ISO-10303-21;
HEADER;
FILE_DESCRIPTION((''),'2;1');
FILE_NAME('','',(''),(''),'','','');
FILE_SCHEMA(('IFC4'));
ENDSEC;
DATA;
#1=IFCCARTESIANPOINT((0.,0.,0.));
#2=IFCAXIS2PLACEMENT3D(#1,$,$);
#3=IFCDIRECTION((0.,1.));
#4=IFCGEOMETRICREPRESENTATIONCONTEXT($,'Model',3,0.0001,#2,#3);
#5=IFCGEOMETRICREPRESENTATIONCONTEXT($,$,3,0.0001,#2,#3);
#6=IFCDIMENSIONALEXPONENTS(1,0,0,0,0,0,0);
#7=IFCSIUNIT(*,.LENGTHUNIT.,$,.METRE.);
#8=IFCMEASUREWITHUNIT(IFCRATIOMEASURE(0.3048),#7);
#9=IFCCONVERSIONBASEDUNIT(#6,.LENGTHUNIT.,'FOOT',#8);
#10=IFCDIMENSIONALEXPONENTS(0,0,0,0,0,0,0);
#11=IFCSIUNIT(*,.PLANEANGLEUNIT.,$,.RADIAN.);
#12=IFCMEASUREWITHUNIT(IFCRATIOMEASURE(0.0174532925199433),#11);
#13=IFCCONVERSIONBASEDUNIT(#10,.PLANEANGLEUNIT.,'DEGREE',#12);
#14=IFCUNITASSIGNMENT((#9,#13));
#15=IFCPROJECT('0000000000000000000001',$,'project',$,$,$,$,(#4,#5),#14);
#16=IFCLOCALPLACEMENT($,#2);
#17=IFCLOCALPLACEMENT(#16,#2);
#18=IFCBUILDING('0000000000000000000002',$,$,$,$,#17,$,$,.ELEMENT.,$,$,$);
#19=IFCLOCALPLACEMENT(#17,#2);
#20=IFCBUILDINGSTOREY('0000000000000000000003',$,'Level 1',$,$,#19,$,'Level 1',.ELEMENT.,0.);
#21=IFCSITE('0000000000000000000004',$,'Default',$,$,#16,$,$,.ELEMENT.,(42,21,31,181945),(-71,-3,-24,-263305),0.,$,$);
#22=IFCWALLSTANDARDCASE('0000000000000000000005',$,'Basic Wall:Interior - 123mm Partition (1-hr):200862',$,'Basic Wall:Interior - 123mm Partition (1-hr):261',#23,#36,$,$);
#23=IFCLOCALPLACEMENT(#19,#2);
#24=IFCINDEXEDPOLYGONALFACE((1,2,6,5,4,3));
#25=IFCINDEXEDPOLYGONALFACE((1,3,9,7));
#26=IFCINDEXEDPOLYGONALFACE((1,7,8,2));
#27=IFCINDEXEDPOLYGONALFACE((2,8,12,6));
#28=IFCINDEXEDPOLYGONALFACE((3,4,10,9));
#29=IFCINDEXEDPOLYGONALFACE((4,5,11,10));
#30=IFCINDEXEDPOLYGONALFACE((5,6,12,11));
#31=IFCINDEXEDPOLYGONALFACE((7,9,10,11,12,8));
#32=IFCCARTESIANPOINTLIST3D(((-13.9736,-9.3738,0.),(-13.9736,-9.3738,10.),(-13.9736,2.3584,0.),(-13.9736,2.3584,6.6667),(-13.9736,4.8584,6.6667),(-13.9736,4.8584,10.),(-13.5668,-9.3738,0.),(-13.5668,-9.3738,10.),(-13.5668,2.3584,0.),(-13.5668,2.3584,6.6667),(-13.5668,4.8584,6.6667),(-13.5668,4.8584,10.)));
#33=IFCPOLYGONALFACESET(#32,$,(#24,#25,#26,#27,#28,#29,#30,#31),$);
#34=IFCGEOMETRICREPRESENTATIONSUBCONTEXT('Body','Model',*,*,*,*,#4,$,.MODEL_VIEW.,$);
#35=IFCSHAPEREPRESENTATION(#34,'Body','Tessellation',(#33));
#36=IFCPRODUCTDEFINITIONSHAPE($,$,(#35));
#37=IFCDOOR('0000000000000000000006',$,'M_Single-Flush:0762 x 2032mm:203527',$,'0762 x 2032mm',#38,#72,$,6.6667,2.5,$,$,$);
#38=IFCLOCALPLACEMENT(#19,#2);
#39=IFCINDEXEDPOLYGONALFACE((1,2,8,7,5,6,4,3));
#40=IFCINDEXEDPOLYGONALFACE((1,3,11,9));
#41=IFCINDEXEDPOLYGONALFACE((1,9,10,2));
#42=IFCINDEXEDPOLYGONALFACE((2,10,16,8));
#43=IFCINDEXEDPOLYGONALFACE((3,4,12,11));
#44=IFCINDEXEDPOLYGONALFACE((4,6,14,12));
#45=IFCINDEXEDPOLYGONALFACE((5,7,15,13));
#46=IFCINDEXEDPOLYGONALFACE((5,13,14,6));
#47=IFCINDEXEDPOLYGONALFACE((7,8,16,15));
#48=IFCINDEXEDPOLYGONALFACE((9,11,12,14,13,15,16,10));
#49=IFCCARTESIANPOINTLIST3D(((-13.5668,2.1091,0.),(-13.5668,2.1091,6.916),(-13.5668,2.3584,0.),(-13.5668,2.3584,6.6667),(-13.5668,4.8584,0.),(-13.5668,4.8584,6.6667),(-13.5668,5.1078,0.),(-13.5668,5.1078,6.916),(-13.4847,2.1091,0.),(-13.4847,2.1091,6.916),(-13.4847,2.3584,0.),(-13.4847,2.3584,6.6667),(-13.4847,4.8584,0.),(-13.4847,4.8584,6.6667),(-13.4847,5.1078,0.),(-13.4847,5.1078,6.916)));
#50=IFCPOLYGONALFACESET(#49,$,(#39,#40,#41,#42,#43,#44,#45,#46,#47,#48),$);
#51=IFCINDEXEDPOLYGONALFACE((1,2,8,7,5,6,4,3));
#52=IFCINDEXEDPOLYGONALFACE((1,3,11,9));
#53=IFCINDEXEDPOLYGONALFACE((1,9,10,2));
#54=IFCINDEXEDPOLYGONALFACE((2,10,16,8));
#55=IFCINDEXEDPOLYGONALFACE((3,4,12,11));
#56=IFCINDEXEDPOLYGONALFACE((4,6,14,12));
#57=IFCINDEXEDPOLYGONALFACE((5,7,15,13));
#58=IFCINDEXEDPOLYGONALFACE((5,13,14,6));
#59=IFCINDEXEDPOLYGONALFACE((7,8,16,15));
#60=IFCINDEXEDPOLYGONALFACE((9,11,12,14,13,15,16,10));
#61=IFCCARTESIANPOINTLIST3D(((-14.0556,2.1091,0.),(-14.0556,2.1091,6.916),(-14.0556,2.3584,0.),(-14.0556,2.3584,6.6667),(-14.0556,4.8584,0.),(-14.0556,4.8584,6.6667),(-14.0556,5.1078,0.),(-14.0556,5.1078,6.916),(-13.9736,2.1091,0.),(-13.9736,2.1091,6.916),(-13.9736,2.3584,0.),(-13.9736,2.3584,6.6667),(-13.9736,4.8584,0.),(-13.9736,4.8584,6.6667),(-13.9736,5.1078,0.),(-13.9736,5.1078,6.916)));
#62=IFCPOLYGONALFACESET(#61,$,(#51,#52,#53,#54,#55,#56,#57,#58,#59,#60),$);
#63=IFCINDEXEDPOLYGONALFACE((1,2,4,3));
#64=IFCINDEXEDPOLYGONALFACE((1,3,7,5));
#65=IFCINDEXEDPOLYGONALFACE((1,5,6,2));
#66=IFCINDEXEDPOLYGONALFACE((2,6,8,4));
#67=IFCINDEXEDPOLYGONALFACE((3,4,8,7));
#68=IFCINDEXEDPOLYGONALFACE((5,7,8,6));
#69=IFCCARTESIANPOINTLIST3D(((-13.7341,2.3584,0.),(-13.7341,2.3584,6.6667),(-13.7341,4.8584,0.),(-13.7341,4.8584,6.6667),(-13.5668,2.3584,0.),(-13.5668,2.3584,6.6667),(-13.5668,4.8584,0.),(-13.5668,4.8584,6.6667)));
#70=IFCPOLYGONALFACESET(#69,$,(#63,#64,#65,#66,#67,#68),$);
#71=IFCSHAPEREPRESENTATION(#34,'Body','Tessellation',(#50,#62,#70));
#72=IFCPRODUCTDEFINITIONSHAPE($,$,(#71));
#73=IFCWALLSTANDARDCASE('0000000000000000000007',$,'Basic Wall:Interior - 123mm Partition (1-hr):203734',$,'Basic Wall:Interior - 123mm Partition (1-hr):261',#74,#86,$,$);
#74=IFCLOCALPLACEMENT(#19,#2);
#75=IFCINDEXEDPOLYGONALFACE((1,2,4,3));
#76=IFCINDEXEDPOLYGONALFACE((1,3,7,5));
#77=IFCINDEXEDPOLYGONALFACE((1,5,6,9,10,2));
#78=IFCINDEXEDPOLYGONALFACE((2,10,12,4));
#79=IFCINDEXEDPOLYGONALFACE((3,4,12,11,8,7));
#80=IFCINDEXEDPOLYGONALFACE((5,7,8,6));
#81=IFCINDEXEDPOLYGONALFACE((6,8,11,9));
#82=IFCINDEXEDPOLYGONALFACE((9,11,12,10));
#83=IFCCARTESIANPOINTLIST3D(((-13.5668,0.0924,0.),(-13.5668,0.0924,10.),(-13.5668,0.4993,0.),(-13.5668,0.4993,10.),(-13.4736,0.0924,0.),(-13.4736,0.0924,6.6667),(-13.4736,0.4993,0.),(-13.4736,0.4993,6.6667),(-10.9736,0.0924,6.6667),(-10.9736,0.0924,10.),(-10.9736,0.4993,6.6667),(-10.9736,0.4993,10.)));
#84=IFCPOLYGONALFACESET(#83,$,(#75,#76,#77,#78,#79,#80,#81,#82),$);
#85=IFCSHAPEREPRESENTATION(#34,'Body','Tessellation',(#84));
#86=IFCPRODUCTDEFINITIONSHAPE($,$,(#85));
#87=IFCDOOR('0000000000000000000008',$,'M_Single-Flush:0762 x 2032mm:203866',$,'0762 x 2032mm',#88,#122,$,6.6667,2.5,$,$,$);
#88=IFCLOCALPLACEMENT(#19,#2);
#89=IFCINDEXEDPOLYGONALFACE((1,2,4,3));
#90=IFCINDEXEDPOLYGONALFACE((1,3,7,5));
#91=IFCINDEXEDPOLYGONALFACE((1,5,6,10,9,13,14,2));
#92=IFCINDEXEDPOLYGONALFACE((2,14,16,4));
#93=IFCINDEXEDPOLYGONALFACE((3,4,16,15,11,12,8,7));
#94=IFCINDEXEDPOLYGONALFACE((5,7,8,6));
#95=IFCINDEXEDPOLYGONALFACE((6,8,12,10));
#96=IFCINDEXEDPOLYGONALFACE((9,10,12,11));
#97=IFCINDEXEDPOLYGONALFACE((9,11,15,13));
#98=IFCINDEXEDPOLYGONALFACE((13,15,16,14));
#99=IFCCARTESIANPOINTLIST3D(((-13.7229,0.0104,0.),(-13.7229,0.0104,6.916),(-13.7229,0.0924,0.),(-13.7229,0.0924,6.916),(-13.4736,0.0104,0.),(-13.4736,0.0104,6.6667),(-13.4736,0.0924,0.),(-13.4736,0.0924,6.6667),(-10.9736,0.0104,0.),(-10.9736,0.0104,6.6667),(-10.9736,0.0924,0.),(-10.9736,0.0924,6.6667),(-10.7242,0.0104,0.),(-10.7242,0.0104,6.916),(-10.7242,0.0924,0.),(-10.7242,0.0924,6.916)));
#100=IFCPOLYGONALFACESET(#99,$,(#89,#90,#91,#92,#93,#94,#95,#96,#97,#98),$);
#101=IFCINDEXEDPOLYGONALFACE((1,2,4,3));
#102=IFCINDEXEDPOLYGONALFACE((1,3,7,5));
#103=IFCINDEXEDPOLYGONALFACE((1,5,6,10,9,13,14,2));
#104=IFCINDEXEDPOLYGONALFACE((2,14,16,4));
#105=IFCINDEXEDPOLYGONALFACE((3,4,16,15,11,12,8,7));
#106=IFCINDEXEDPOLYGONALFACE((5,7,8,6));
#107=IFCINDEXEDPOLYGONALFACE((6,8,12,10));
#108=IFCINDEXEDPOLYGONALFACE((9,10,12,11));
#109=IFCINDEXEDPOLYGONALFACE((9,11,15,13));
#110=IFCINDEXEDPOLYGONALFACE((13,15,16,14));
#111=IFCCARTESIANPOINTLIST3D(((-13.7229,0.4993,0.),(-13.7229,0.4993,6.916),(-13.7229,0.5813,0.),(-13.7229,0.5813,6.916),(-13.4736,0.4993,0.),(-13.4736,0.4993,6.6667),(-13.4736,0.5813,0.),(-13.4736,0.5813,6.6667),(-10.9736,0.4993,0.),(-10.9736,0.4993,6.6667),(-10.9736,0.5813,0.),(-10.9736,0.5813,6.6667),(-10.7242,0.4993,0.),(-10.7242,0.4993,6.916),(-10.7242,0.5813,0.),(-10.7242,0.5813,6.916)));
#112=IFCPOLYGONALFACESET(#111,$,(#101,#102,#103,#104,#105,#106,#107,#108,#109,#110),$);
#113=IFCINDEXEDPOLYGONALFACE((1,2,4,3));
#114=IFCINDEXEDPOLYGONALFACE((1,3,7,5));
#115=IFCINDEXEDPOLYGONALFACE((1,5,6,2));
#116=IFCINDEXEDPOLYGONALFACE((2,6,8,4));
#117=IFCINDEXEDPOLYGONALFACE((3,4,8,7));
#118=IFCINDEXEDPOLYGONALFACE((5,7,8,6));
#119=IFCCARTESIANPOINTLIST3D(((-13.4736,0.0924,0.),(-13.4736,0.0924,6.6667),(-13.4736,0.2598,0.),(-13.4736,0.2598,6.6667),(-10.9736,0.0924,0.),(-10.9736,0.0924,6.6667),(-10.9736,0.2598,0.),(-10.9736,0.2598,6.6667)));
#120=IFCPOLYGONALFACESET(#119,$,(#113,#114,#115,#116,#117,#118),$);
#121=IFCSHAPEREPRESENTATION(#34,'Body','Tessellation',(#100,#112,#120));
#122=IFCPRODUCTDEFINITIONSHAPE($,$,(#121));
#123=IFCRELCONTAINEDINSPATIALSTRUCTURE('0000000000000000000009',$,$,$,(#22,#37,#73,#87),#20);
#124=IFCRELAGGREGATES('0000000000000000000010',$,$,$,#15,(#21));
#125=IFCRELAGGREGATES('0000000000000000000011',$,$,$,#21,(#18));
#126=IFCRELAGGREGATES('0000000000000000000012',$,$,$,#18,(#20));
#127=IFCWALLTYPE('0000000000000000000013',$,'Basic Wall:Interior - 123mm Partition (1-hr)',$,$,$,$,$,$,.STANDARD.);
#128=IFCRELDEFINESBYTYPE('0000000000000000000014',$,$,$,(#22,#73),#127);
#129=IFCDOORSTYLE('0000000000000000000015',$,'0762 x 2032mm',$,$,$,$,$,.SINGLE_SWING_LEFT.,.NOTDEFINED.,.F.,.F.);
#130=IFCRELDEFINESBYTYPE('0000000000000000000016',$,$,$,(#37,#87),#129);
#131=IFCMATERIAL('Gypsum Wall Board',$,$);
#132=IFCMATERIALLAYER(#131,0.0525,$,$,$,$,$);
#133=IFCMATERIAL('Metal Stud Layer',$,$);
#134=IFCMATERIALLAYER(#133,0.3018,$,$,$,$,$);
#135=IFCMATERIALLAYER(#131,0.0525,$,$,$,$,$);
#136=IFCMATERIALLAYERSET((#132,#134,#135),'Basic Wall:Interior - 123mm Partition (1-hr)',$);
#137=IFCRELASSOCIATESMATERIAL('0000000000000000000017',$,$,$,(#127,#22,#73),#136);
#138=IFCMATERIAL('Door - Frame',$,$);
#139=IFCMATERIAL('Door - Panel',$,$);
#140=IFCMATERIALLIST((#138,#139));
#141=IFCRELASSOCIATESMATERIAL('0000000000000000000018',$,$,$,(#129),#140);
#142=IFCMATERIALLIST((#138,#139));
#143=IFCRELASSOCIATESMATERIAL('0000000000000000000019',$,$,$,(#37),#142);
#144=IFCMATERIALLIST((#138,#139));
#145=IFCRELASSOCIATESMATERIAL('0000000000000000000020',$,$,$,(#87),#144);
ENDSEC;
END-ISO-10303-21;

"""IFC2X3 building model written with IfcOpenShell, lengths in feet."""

from ifc_helpers import new_model, entity, si_unit, converted_unit, direction, frame, frame_2d, origin, origin_2d_with_axis, place, context, subcontext, project, spatial, polyline, rectangle, outline, extrude, source, transform, mapped, material, material_list, layer, layer_set, layer_usage, type_object, type_shapes, element, fill, save


model = new_model("IFC2X3")

# Units and contexts
model_context = context("Model", 3, precision=0.0001, world=origin(), true_north=direction((0.0, 1.0)))
context_of_model = context(None, 3, precision=0.0001, world=origin(), true_north=direction((0.0, 1.0)))
body_context = subcontext(model_context, "Body", "Model", "MODEL_VIEW")
ifc_project = project(units=[converted_unit("LENGTHUNIT", "FOOT", entity("IfcRatioMeasure", 0.3048), si_unit("LENGTHUNIT", "METRE"), dimensions=[1, 0, 0, 0, 0, 0, 0]), converted_unit("PLANEANGLEUNIT", "DEGREE", entity("IfcRatioMeasure", 0.0174532925199433), si_unit("PLANEANGLEUNIT", "RADIAN"), dimensions=[0, 0, 0, 0, 0, 0, 0])], contexts=[model_context, context_of_model])

# Site, building, storey
site_placement = place(None, origin())
site = spatial("IfcSite", under=ifc_project, at=site_placement, Name="Default", CompositionType="ELEMENT", RefLatitude=(42, 21, 31, 181945), RefLongitude=(-71, -3, -24, -263305), RefElevation=0.0)
building_placement = place(site_placement, origin())
building = spatial("IfcBuilding", under=site, at=building_placement, CompositionType="ELEMENT")
storey_placement = place(building_placement, origin())
storey = spatial("IfcBuildingStorey", under=building, at=storey_placement, Name="Level 1", LongName="Level 1", CompositionType="ELEMENT", Elevation=0.0)

# Shared definitions
ifc_material_1 = material(Name="Door - Frame")
ifc_material_2 = material(Name="Door - Panel")

# Shared definitions
ifc_material_3 = material(Name="Gypsum Wall Board")
ifc_layer_1 = layer(ifc_material_3, 0.0525)
ifc_material_4 = material(Name="Metal Stud Layer")
ifc_layer_2 = layer(ifc_material_4, 0.3018)
ifc_layer_3 = layer(ifc_material_3, 0.0525)
ifc_layer_set_1 = layer_set([ifc_layer_1, ifc_layer_2, ifc_layer_3], Name="Basic Wall:Interior - 123mm Partition (1-hr)")
wall_type_1 = type_object("IfcWallType", Name="Basic Wall:Interior - 123mm Partition (1-hr)", PredefinedType="STANDARD", material=ifc_layer_set_1)

# Wall, openings, door
ifc_layer_usage_1 = layer_usage(ifc_layer_set_1, "AXIS2", "NEGATIVE", 0.2034)
wall_1_placement = place(storey_placement, frame((-13.7702, -9.3738, 0.0), z_axis=(0.0, 0.0, 1.0), x_axis=(0.0, 1.0, 0.0)))
wall_1 = element("IfcWallStandardCase", 1, at=wall_1_placement, inside=storey, type_object=wall_type_1, material=ifc_layer_usage_1, Name="Basic Wall:Interior - 123mm Partition (1-hr):200862", ObjectType="Basic Wall:Interior - 123mm Partition (1-hr):261", context=body_context, shape_type="SweptSolid", body=[
    extrude(rectangle(XDim=14.2323, YDim=0.4068, at=frame_2d((7.1161, 0.0), x_axis=(-1.0, 0.0))), origin(), (0.0, 0.0, 1.0), 10.0),
])
opening_1_placement = place(wall_1_placement, origin())
element("IfcOpeningElement", 2, at=opening_1_placement, cuts=wall_1, ObjectType="Opening", context=body_context, shape_type="SweptSolid", body=[
    extrude(rectangle(XDim=6.6667, YDim=0.4068, at=frame_2d((0.0, 0.0), x_axis=(0.0, 1.0))), frame((9.6697, -2.7966, 3.3333), z_axis=(0.0, 1.0, 0.0), x_axis=(1.0, 0.0, 0.0)), (0.0, 0.0, 1.0), 2.5),
])
opening_2_placement = place(wall_1_placement, frame((14.2323, 0.2034, 0.0)))
opening_2 = element("IfcOpeningElement", 3, at=opening_2_placement, cuts=wall_1, ObjectType="Opening", context=body_context, shape_type="SweptSolid", body=[
    extrude(rectangle(XDim=2.5, YDim=6.6667, at=frame_2d((3.3333, 1.25), x_axis=(0.0, -1.0))), frame((0.0, 0.0, 0.0), z_axis=(0.0, -1.0, 0.0), x_axis=(0.0, 0.0, 1.0)), (0.0, 0.0, 1.0), 0.4068),
])
ifc_material_list_1 = material_list([ifc_material_1, ifc_material_2])
ifc_material_list_2 = material_list([ifc_material_1, ifc_material_2])
door_style_1 = type_object("IfcDoorStyle", Name="0762 x 2032mm", ConstructionType="NOTDEFINED", OperationType="SINGLE_SWING_LEFT", ParameterTakesPrecedence=False, Sizeable=False, material=ifc_material_list_2)
shared_shape_1 = source(origin(), body_context, "Body", "SweptSolid", [
    extrude(outline(polyline([(-1.4993, -3.5203), (1.4993, -3.5203), (1.4993, 3.3957), (1.25, 3.3957), (1.25, -3.271), (-1.25, -3.271), (-1.25, 3.3957), (-1.4993, 3.3957), (-1.4993, -3.5203)])), frame((1.25, 0.4888, 3.3957), z_axis=(0.0, -1.0, 0.0), x_axis=(-1.0, 0.0, 0.0)), (0.0, 0.0, 1.0), 0.082),
    extrude(outline(polyline([(-3.5203, -1.4993), (3.3957, -1.4993), (3.3957, -1.25), (-3.271, -1.25), (-3.271, 1.25), (3.3957, 1.25), (3.3957, 1.4993), (-3.5203, 1.4993), (-3.5203, -1.4993)])), frame((1.25, 0.0, 3.3957), z_axis=(0.0, -1.0, 0.0), x_axis=(0.0, 0.0, -1.0)), (0.0, 0.0, 1.0), 0.082),
    extrude(rectangle(XDim=2.5, YDim=0.1673, at=origin_2d_with_axis()), frame((1.25, 0.3232, 0.0)), (0.0, 0.0, 1.0), 6.6667),
])
type_shapes(door_style_1, [shared_shape_1])
door_1_placement = place(opening_2_placement, frame((0.0, 0.0, 0.0), z_axis=(0.0, 0.0, 1.0), x_axis=(-1.0, 0.0, 0.0)))
door_1 = element("IfcDoor", 4, at=door_1_placement, inside=storey, type_object=door_style_1, material=ifc_material_list_1, Name="M_Single-Flush:0762 x 2032mm:203527", ObjectType="0762 x 2032mm", OverallHeight=6.6667, OverallWidth=2.5, context=body_context, shape_type="MappedRepresentation", body=[
    mapped(shared_shape_1, transform((0.0, 0.0, 0.0), scale=1.0)),
])
fill(opening_2, door_1)

# Wall, opening, door
ifc_layer_usage_2 = layer_usage(ifc_layer_set_1, "AXIS2", "NEGATIVE", 0.2034)
wall_2_placement = place(storey_placement, frame((-13.5668, 0.2959, 0.0)))
wall_2 = element("IfcWallStandardCase", 5, at=wall_2_placement, inside=storey, type_object=wall_type_1, material=ifc_layer_usage_2, Name="Basic Wall:Interior - 123mm Partition (1-hr):203734", ObjectType="Basic Wall:Interior - 123mm Partition (1-hr):261", context=body_context, shape_type="SweptSolid", body=[
    extrude(rectangle(XDim=2.5932, YDim=0.4068, at=frame_2d((1.2966, 0.0), x_axis=(-1.0, 0.0))), origin(), (0.0, 0.0, 1.0), 10.0),
])
opening_3_placement = place(wall_2_placement, frame((2.5932, 0.2034, 0.0)))
opening_3 = element("IfcOpeningElement", 6, at=opening_3_placement, cuts=wall_2, ObjectType="Opening", context=body_context, shape_type="SweptSolid", body=[
    extrude(rectangle(XDim=2.5, YDim=6.6667, at=frame_2d((3.3333, 1.25), x_axis=(0.0, -1.0))), frame((0.0, 0.0, 0.0), z_axis=(0.0, -1.0, 0.0), x_axis=(0.0, 0.0, 1.0)), (0.0, 0.0, 1.0), 0.4068),
])
ifc_material_list_3 = material_list([ifc_material_1, ifc_material_2])
door_2_placement = place(opening_3_placement, frame((0.0, 0.0, 0.0), z_axis=(0.0, 0.0, 1.0), x_axis=(-1.0, 0.0, 0.0)))
door_2 = element("IfcDoor", 7, at=door_2_placement, inside=storey, type_object=door_style_1, material=ifc_material_list_3, Name="M_Single-Flush:0762 x 2032mm:203866", ObjectType="0762 x 2032mm", OverallHeight=6.6667, OverallWidth=2.5, context=body_context, shape_type="MappedRepresentation", body=[
    mapped(shared_shape_1, transform((0.0, 0.0, 0.0), scale=1.0)),
])
fill(opening_3, door_2)

save(model, "model.ifc")
